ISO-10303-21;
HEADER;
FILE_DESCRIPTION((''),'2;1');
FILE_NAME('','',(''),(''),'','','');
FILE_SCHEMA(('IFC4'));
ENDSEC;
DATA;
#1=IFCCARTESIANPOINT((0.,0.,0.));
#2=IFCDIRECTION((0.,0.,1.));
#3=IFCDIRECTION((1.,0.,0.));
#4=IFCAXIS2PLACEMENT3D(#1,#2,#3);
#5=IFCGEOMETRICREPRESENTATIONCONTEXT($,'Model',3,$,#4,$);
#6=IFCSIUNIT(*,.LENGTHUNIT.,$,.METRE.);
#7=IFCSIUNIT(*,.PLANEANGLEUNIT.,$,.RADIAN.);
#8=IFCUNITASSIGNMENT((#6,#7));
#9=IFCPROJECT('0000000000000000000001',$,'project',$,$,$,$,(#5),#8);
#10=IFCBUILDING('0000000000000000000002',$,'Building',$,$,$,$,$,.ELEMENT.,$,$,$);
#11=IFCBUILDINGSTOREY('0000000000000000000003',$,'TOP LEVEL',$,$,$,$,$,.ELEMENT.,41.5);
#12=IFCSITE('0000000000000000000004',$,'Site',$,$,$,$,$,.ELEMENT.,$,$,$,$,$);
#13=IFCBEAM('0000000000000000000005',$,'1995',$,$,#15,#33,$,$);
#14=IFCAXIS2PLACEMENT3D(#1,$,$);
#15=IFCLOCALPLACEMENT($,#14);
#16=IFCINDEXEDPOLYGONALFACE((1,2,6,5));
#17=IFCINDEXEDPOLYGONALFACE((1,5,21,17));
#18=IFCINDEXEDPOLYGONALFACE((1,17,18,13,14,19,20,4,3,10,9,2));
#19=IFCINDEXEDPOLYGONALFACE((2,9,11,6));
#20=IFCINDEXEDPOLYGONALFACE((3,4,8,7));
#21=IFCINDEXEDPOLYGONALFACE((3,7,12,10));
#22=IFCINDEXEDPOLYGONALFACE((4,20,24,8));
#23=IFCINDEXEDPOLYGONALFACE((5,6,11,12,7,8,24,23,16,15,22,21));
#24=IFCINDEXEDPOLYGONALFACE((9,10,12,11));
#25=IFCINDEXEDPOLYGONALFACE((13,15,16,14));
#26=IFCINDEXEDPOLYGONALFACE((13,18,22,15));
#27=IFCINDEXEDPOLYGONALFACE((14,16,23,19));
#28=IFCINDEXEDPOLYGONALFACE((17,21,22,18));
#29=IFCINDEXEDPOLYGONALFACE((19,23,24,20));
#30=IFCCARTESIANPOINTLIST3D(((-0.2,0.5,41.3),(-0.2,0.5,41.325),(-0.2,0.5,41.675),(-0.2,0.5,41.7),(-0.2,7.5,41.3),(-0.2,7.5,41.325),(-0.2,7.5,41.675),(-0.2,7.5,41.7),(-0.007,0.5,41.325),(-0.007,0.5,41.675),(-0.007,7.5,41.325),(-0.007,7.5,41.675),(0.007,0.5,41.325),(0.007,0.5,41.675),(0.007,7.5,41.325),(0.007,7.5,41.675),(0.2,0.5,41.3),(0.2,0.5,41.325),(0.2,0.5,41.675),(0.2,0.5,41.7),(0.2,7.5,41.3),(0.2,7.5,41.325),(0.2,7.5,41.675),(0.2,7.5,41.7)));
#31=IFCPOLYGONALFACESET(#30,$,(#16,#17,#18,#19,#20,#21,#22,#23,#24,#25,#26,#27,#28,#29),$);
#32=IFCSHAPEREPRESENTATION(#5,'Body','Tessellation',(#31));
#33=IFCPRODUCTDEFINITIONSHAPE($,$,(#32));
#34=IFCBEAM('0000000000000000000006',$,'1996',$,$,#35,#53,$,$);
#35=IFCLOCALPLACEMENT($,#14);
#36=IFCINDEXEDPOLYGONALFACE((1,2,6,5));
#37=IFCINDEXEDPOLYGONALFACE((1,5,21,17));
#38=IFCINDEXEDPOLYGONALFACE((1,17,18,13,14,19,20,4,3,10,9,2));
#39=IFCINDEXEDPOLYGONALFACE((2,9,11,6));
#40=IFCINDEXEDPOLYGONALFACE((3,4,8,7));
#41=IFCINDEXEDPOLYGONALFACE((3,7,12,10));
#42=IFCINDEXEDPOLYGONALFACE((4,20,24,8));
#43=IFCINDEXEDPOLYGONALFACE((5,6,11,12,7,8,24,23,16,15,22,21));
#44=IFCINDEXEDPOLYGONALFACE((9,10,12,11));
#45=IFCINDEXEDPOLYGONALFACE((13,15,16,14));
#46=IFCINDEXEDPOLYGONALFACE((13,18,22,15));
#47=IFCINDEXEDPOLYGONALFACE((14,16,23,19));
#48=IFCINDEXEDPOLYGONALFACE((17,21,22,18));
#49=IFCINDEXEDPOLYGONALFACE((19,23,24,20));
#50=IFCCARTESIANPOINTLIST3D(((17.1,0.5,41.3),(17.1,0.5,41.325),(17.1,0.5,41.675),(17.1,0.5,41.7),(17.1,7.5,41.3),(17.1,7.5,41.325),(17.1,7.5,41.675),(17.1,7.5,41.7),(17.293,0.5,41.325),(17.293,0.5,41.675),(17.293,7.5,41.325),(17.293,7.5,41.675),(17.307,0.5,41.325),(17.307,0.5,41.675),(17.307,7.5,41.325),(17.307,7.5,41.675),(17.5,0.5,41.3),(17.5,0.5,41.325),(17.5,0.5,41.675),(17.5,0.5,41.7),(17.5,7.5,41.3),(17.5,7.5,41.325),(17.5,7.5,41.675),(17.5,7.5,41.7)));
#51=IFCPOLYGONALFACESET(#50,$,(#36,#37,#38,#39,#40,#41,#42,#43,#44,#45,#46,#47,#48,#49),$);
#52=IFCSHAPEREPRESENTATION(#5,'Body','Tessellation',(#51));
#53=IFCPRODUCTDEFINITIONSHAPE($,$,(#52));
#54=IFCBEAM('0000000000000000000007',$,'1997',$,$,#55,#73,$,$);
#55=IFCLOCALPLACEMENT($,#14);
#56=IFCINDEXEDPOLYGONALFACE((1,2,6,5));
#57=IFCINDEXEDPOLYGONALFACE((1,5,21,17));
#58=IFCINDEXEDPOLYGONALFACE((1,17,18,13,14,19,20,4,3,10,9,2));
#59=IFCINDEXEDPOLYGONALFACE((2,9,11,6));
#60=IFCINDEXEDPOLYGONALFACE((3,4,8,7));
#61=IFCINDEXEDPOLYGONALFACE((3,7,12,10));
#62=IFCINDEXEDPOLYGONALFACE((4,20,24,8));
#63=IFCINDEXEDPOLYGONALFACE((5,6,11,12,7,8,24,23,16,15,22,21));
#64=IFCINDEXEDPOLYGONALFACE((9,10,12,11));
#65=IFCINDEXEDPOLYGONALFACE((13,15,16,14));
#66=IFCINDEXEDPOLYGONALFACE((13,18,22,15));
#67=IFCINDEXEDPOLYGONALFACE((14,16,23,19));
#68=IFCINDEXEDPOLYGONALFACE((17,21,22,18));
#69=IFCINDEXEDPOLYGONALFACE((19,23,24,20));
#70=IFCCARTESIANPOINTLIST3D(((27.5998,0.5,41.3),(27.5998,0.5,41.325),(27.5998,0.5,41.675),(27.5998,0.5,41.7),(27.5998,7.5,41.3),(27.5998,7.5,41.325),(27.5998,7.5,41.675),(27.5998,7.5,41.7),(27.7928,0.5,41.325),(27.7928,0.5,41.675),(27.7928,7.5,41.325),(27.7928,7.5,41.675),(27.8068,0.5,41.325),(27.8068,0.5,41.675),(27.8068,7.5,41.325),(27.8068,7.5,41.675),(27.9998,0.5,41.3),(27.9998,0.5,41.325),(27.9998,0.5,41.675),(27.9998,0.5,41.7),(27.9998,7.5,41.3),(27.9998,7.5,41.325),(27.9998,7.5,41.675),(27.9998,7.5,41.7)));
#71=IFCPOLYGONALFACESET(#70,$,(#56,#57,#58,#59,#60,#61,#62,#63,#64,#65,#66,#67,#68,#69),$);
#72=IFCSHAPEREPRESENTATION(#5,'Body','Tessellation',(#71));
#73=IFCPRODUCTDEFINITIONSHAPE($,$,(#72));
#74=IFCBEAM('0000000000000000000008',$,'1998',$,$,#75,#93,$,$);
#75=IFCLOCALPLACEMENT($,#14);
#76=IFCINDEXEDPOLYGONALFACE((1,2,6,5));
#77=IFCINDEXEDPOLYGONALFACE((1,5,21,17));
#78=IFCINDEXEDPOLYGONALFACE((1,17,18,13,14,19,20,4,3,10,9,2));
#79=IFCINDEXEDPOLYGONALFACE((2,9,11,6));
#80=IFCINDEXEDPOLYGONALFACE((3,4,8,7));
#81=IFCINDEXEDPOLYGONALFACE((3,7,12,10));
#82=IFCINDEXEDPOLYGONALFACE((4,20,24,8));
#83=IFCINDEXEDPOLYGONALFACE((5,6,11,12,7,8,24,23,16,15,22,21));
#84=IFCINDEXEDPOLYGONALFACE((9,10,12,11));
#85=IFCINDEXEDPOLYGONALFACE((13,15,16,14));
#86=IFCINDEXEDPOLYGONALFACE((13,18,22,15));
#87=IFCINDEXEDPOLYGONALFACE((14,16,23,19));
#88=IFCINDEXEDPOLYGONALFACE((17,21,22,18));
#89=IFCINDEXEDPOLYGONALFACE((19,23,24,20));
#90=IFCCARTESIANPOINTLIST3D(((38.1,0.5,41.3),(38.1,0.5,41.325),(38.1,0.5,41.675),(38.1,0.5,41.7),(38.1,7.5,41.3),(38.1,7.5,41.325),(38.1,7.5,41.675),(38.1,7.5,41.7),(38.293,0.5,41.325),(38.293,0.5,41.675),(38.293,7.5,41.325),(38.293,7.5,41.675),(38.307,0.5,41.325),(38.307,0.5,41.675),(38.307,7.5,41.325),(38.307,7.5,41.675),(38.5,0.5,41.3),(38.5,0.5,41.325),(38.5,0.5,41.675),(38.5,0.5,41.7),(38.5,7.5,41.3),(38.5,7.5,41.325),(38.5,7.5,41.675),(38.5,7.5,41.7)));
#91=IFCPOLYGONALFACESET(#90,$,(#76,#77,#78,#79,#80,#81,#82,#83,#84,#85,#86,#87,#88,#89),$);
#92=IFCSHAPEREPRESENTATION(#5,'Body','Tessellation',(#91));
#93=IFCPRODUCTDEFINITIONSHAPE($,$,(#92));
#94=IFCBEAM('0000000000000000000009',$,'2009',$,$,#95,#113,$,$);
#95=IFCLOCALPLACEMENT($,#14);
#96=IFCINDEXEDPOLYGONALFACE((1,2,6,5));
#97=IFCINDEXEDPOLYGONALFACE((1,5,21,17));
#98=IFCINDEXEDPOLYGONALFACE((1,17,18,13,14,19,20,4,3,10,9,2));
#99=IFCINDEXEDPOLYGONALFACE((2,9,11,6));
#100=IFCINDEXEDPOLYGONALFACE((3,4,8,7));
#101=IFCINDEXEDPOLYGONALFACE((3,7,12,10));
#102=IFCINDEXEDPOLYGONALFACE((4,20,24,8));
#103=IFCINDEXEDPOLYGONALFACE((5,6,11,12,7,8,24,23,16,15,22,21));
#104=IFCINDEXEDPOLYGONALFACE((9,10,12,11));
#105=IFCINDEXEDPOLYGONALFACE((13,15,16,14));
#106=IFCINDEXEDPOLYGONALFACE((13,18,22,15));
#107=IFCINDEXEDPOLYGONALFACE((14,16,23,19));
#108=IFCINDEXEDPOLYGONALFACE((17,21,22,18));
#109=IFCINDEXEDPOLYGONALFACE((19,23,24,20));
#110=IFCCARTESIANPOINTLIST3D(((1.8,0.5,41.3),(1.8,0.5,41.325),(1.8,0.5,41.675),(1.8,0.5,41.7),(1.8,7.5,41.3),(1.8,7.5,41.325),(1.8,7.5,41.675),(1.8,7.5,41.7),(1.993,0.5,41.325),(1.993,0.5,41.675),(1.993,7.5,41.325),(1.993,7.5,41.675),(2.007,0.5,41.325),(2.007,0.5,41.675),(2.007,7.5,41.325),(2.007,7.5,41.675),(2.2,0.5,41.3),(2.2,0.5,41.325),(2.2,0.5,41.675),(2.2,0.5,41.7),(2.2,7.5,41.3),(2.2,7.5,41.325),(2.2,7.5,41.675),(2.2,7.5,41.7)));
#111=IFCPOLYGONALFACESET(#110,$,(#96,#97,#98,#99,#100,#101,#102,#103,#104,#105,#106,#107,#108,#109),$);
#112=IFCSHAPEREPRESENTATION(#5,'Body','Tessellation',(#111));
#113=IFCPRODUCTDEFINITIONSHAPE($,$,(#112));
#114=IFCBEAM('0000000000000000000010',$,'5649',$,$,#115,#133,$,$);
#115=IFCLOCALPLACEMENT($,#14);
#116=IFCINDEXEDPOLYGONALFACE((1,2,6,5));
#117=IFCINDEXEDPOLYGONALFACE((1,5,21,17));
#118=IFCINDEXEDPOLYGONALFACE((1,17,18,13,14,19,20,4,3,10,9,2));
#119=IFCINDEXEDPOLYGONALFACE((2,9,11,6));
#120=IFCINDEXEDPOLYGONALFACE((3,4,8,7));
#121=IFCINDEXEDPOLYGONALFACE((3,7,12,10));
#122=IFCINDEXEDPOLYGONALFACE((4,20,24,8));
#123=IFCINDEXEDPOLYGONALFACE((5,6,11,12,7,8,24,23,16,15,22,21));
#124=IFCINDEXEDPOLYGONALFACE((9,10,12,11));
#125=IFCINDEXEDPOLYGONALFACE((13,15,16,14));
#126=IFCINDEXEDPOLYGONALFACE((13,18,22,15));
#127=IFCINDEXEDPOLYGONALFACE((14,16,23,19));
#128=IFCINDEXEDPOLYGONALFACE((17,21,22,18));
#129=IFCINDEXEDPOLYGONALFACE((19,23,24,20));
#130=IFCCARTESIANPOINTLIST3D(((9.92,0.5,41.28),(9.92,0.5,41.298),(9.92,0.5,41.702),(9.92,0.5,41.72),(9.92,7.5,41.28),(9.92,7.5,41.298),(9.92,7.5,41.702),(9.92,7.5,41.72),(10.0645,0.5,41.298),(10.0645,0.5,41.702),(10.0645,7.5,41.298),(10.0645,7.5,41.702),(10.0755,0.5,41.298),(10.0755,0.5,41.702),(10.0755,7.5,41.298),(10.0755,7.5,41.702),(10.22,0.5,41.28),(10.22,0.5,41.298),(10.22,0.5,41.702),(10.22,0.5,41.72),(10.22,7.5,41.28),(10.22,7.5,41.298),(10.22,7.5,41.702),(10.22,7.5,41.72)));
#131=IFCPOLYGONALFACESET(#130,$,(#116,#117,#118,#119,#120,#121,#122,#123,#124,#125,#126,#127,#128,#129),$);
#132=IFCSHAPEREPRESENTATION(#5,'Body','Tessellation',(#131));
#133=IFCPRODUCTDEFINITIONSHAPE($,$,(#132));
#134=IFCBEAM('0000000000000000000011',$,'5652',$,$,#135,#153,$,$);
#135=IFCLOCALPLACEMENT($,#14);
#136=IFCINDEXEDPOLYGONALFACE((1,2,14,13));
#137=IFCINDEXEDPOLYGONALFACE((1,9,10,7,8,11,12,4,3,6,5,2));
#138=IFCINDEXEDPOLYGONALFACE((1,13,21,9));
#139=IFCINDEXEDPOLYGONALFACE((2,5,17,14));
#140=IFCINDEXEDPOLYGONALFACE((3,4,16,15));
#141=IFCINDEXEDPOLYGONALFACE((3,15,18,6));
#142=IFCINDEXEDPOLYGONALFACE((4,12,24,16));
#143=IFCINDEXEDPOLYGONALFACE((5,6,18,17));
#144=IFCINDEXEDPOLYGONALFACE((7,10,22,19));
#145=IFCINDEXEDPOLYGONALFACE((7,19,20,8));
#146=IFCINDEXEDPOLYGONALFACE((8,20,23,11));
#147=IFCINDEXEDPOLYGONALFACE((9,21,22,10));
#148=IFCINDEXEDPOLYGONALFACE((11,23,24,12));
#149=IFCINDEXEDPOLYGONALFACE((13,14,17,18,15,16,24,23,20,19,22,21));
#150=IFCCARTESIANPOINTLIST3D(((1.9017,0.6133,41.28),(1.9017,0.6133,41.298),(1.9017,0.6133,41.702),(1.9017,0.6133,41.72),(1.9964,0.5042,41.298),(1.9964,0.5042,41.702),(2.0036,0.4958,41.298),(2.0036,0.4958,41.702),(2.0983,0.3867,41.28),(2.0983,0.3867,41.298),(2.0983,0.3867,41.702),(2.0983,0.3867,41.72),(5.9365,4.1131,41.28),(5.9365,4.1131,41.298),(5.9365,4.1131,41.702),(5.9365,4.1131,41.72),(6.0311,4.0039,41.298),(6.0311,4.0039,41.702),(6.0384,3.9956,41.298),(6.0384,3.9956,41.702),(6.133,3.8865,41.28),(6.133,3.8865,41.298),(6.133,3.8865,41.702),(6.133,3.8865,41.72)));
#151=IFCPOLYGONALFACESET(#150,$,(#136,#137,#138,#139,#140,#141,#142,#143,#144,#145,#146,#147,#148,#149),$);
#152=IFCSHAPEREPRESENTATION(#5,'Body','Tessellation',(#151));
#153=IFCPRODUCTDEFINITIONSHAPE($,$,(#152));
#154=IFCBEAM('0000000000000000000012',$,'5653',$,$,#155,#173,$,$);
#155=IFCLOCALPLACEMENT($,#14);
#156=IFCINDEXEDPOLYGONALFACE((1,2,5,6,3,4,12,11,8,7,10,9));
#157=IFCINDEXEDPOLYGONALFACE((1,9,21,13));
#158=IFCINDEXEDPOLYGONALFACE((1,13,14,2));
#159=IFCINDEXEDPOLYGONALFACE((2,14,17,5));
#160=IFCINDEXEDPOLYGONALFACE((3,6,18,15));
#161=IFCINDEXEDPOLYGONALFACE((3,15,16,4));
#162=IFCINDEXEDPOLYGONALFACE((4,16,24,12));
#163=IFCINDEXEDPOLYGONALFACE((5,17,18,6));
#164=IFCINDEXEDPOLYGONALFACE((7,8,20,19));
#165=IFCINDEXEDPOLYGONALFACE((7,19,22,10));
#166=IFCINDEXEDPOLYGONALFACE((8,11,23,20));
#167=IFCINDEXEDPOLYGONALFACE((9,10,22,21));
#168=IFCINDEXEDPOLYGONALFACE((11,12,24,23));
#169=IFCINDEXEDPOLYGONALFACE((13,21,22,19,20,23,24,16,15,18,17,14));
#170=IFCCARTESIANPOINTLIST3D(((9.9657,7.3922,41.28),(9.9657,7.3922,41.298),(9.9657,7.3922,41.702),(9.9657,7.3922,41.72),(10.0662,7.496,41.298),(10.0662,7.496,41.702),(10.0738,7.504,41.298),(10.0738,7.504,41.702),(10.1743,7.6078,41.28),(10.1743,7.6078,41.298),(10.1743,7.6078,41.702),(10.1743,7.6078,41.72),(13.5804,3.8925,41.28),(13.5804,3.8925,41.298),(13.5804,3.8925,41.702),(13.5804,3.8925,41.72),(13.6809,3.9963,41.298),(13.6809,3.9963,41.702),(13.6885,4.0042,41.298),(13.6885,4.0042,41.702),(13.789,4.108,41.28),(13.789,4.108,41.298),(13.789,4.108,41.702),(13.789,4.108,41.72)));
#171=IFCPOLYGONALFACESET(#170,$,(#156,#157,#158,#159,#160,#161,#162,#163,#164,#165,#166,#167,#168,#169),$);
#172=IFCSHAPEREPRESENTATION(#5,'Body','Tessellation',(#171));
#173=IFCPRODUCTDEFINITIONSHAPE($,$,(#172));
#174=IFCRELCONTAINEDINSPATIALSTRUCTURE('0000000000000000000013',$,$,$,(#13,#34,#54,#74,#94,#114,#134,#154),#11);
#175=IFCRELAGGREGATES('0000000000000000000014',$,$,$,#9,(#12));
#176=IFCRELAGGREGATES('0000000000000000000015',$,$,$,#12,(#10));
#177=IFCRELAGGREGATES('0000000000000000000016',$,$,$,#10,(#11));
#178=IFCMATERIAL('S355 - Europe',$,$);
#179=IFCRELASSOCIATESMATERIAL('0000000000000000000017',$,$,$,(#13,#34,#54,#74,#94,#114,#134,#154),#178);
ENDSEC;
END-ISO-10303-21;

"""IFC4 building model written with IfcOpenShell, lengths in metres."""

from ifc_helpers import new_model, si_unit, frame, origin_with_axes, origin_2d_with_axis, place, context, project, spatial, i_section, extrude, material, material_profile, profile_set, profile_usage, element, save


model = new_model("IFC4")

# Units and contexts
model_context = context("Model", 3, world=origin_with_axes())
ifc_project = project(units=[si_unit("LENGTHUNIT", "METRE"), si_unit("PLANEANGLEUNIT", "RADIAN")], contexts=[model_context])

# Site, building, storey
site = spatial("IfcSite", under=ifc_project, Name="Site", CompositionType="ELEMENT")
building = spatial("IfcBuilding", under=site, Name="Building", CompositionType="ELEMENT")
storey = spatial("IfcBuildingStorey", under=building, Name="TOP LEVEL", CompositionType="ELEMENT", Elevation=41.5)

# Beams
ifc_material = material(Name="S355 - Europe")
ifc_material_profile_1 = material_profile(ifc_material, i_section(OverallWidth=0.4, OverallDepth=0.4, WebThickness=0.014, FlangeThickness=0.025, at=origin_2d_with_axis()))
ifc_profile_set_1 = profile_set([ifc_material_profile_1])
ifc_profile_usage_1 = profile_usage(ifc_profile_set_1, cardinal=10)
beam_1_placement = place(None, frame((0.0, 7.5, 41.5), z_axis=(0.0, -1.0, 0.0), x_axis=(1.0, 0.0, 0.0)))
element("IfcBeam", 1, at=beam_1_placement, inside=storey, material=ifc_profile_usage_1, Name="1995", context=model_context, shape_type="SweptSolid", body=[
    extrude(i_section(OverallWidth=0.4, OverallDepth=0.4, WebThickness=0.014, FlangeThickness=0.025, at=origin_2d_with_axis()), origin_with_axes(), (0.0, 0.0, 1.0), 7.0),
])
ifc_material_profile_2 = material_profile(ifc_material, i_section(OverallWidth=0.4, OverallDepth=0.4, WebThickness=0.014, FlangeThickness=0.025, at=origin_2d_with_axis()))
ifc_profile_set_2 = profile_set([ifc_material_profile_2])
ifc_profile_usage_2 = profile_usage(ifc_profile_set_2, cardinal=10)
beam_2_placement = place(None, frame((17.3, 7.5, 41.5), z_axis=(0.0, -1.0, 0.0), x_axis=(1.0, 0.0, 0.0)))
element("IfcBeam", 2, at=beam_2_placement, inside=storey, material=ifc_profile_usage_2, Name="1996", context=model_context, shape_type="SweptSolid", body=[
    extrude(i_section(OverallWidth=0.4, OverallDepth=0.4, WebThickness=0.014, FlangeThickness=0.025, at=origin_2d_with_axis()), origin_with_axes(), (0.0, 0.0, 1.0), 7.0),
])
ifc_material_profile_3 = material_profile(ifc_material, i_section(OverallWidth=0.4, OverallDepth=0.4, WebThickness=0.014, FlangeThickness=0.025, at=origin_2d_with_axis()))
ifc_profile_set_3 = profile_set([ifc_material_profile_3])
ifc_profile_usage_3 = profile_usage(ifc_profile_set_3, cardinal=10)
beam_3_placement = place(None, frame((27.7998, 7.5, 41.5), z_axis=(0.0, -1.0, 0.0), x_axis=(1.0, 0.0, 0.0)))
element("IfcBeam", 3, at=beam_3_placement, inside=storey, material=ifc_profile_usage_3, Name="1997", context=model_context, shape_type="SweptSolid", body=[
    extrude(i_section(OverallWidth=0.4, OverallDepth=0.4, WebThickness=0.014, FlangeThickness=0.025, at=origin_2d_with_axis()), origin_with_axes(), (0.0, 0.0, 1.0), 7.0),
])
ifc_material_profile_4 = material_profile(ifc_material, i_section(OverallWidth=0.4, OverallDepth=0.4, WebThickness=0.014, FlangeThickness=0.025, at=origin_2d_with_axis()))
ifc_profile_set_4 = profile_set([ifc_material_profile_4])
ifc_profile_usage_4 = profile_usage(ifc_profile_set_4, cardinal=10)
beam_4_placement = place(None, frame((38.3, 7.5, 41.5), z_axis=(0.0, -1.0, 0.0), x_axis=(1.0, 0.0, 0.0)))
element("IfcBeam", 4, at=beam_4_placement, inside=storey, material=ifc_profile_usage_4, Name="1998", context=model_context, shape_type="SweptSolid", body=[
    extrude(i_section(OverallWidth=0.4, OverallDepth=0.4, WebThickness=0.014, FlangeThickness=0.025, at=origin_2d_with_axis()), origin_with_axes(), (0.0, 0.0, 1.0), 7.0),
])
ifc_material_profile_5 = material_profile(ifc_material, i_section(OverallWidth=0.4, OverallDepth=0.4, WebThickness=0.014, FlangeThickness=0.025, at=origin_2d_with_axis()))
ifc_profile_set_5 = profile_set([ifc_material_profile_5])
ifc_profile_usage_5 = profile_usage(ifc_profile_set_5, cardinal=10)
beam_5_placement = place(None, frame((2.0, 7.5, 41.5), z_axis=(0.0, -1.0, 0.0), x_axis=(1.0, 0.0, 0.0)))
element("IfcBeam", 5, at=beam_5_placement, inside=storey, material=ifc_profile_usage_5, Name="2009", context=model_context, shape_type="SweptSolid", body=[
    extrude(i_section(OverallWidth=0.4, OverallDepth=0.4, WebThickness=0.014, FlangeThickness=0.025, at=origin_2d_with_axis()), origin_with_axes(), (0.0, 0.0, 1.0), 7.0),
])
ifc_material_profile_6 = material_profile(ifc_material, i_section(OverallWidth=0.3, OverallDepth=0.44, WebThickness=0.011, FlangeThickness=0.018, at=origin_2d_with_axis()))
ifc_profile_set_6 = profile_set([ifc_material_profile_6])
ifc_profile_usage_6 = profile_usage(ifc_profile_set_6, cardinal=10)
beam_6_placement = place(None, frame((10.07, 7.5, 41.5), z_axis=(0.0, -1.0, 0.0), x_axis=(1.0, 0.0, 0.0)))
element("IfcBeam", 6, at=beam_6_placement, inside=storey, material=ifc_profile_usage_6, Name="5649", context=model_context, shape_type="SweptSolid", body=[
    extrude(i_section(OverallWidth=0.3, OverallDepth=0.44, WebThickness=0.011, FlangeThickness=0.018, at=origin_2d_with_axis()), origin_with_axes(), (0.0, 0.0, 1.0), 7.0),
])
ifc_material_profile_7 = material_profile(ifc_material, i_section(OverallWidth=0.3, OverallDepth=0.44, WebThickness=0.011, FlangeThickness=0.018, at=origin_2d_with_axis()))
ifc_profile_set_7 = profile_set([ifc_material_profile_7])
ifc_profile_usage_7 = profile_usage(ifc_profile_set_7, cardinal=10)
beam_7_placement = place(None, frame((2.0, 0.5, 41.5), z_axis=(0.755412, 0.65525, 0.0), x_axis=(-0.65525, 0.755412, 0.0)))
element("IfcBeam", 7, at=beam_7_placement, inside=storey, material=ifc_profile_usage_7, Name="5652", context=model_context, shape_type="SweptSolid", body=[
    extrude(i_section(OverallWidth=0.3, OverallDepth=0.44, WebThickness=0.011, FlangeThickness=0.018, at=origin_2d_with_axis()), origin_with_axes(), (0.0, 0.0, 1.0), 5.3411),
])
ifc_material_profile_8 = material_profile(ifc_material, i_section(OverallWidth=0.3, OverallDepth=0.44, WebThickness=0.011, FlangeThickness=0.018, at=origin_2d_with_axis()))
ifc_profile_set_8 = profile_set([ifc_material_profile_8])
ifc_profile_usage_8 = profile_usage(ifc_profile_set_8, cardinal=10)
beam_8_placement = place(None, frame((10.07, 7.5, 41.5), z_axis=(0.718439, -0.69559, 0.0), x_axis=(0.69559, 0.718439, 0.0)))
element("IfcBeam", 8, at=beam_8_placement, inside=storey, material=ifc_profile_usage_8, Name="5653", context=model_context, shape_type="SweptSolid", body=[
    extrude(i_section(OverallWidth=0.3, OverallDepth=0.44, WebThickness=0.011, FlangeThickness=0.018, at=origin_2d_with_axis()), origin_with_axes(), (0.0, 0.0, 1.0), 5.0313),
])

save(model, "model.ifc")
